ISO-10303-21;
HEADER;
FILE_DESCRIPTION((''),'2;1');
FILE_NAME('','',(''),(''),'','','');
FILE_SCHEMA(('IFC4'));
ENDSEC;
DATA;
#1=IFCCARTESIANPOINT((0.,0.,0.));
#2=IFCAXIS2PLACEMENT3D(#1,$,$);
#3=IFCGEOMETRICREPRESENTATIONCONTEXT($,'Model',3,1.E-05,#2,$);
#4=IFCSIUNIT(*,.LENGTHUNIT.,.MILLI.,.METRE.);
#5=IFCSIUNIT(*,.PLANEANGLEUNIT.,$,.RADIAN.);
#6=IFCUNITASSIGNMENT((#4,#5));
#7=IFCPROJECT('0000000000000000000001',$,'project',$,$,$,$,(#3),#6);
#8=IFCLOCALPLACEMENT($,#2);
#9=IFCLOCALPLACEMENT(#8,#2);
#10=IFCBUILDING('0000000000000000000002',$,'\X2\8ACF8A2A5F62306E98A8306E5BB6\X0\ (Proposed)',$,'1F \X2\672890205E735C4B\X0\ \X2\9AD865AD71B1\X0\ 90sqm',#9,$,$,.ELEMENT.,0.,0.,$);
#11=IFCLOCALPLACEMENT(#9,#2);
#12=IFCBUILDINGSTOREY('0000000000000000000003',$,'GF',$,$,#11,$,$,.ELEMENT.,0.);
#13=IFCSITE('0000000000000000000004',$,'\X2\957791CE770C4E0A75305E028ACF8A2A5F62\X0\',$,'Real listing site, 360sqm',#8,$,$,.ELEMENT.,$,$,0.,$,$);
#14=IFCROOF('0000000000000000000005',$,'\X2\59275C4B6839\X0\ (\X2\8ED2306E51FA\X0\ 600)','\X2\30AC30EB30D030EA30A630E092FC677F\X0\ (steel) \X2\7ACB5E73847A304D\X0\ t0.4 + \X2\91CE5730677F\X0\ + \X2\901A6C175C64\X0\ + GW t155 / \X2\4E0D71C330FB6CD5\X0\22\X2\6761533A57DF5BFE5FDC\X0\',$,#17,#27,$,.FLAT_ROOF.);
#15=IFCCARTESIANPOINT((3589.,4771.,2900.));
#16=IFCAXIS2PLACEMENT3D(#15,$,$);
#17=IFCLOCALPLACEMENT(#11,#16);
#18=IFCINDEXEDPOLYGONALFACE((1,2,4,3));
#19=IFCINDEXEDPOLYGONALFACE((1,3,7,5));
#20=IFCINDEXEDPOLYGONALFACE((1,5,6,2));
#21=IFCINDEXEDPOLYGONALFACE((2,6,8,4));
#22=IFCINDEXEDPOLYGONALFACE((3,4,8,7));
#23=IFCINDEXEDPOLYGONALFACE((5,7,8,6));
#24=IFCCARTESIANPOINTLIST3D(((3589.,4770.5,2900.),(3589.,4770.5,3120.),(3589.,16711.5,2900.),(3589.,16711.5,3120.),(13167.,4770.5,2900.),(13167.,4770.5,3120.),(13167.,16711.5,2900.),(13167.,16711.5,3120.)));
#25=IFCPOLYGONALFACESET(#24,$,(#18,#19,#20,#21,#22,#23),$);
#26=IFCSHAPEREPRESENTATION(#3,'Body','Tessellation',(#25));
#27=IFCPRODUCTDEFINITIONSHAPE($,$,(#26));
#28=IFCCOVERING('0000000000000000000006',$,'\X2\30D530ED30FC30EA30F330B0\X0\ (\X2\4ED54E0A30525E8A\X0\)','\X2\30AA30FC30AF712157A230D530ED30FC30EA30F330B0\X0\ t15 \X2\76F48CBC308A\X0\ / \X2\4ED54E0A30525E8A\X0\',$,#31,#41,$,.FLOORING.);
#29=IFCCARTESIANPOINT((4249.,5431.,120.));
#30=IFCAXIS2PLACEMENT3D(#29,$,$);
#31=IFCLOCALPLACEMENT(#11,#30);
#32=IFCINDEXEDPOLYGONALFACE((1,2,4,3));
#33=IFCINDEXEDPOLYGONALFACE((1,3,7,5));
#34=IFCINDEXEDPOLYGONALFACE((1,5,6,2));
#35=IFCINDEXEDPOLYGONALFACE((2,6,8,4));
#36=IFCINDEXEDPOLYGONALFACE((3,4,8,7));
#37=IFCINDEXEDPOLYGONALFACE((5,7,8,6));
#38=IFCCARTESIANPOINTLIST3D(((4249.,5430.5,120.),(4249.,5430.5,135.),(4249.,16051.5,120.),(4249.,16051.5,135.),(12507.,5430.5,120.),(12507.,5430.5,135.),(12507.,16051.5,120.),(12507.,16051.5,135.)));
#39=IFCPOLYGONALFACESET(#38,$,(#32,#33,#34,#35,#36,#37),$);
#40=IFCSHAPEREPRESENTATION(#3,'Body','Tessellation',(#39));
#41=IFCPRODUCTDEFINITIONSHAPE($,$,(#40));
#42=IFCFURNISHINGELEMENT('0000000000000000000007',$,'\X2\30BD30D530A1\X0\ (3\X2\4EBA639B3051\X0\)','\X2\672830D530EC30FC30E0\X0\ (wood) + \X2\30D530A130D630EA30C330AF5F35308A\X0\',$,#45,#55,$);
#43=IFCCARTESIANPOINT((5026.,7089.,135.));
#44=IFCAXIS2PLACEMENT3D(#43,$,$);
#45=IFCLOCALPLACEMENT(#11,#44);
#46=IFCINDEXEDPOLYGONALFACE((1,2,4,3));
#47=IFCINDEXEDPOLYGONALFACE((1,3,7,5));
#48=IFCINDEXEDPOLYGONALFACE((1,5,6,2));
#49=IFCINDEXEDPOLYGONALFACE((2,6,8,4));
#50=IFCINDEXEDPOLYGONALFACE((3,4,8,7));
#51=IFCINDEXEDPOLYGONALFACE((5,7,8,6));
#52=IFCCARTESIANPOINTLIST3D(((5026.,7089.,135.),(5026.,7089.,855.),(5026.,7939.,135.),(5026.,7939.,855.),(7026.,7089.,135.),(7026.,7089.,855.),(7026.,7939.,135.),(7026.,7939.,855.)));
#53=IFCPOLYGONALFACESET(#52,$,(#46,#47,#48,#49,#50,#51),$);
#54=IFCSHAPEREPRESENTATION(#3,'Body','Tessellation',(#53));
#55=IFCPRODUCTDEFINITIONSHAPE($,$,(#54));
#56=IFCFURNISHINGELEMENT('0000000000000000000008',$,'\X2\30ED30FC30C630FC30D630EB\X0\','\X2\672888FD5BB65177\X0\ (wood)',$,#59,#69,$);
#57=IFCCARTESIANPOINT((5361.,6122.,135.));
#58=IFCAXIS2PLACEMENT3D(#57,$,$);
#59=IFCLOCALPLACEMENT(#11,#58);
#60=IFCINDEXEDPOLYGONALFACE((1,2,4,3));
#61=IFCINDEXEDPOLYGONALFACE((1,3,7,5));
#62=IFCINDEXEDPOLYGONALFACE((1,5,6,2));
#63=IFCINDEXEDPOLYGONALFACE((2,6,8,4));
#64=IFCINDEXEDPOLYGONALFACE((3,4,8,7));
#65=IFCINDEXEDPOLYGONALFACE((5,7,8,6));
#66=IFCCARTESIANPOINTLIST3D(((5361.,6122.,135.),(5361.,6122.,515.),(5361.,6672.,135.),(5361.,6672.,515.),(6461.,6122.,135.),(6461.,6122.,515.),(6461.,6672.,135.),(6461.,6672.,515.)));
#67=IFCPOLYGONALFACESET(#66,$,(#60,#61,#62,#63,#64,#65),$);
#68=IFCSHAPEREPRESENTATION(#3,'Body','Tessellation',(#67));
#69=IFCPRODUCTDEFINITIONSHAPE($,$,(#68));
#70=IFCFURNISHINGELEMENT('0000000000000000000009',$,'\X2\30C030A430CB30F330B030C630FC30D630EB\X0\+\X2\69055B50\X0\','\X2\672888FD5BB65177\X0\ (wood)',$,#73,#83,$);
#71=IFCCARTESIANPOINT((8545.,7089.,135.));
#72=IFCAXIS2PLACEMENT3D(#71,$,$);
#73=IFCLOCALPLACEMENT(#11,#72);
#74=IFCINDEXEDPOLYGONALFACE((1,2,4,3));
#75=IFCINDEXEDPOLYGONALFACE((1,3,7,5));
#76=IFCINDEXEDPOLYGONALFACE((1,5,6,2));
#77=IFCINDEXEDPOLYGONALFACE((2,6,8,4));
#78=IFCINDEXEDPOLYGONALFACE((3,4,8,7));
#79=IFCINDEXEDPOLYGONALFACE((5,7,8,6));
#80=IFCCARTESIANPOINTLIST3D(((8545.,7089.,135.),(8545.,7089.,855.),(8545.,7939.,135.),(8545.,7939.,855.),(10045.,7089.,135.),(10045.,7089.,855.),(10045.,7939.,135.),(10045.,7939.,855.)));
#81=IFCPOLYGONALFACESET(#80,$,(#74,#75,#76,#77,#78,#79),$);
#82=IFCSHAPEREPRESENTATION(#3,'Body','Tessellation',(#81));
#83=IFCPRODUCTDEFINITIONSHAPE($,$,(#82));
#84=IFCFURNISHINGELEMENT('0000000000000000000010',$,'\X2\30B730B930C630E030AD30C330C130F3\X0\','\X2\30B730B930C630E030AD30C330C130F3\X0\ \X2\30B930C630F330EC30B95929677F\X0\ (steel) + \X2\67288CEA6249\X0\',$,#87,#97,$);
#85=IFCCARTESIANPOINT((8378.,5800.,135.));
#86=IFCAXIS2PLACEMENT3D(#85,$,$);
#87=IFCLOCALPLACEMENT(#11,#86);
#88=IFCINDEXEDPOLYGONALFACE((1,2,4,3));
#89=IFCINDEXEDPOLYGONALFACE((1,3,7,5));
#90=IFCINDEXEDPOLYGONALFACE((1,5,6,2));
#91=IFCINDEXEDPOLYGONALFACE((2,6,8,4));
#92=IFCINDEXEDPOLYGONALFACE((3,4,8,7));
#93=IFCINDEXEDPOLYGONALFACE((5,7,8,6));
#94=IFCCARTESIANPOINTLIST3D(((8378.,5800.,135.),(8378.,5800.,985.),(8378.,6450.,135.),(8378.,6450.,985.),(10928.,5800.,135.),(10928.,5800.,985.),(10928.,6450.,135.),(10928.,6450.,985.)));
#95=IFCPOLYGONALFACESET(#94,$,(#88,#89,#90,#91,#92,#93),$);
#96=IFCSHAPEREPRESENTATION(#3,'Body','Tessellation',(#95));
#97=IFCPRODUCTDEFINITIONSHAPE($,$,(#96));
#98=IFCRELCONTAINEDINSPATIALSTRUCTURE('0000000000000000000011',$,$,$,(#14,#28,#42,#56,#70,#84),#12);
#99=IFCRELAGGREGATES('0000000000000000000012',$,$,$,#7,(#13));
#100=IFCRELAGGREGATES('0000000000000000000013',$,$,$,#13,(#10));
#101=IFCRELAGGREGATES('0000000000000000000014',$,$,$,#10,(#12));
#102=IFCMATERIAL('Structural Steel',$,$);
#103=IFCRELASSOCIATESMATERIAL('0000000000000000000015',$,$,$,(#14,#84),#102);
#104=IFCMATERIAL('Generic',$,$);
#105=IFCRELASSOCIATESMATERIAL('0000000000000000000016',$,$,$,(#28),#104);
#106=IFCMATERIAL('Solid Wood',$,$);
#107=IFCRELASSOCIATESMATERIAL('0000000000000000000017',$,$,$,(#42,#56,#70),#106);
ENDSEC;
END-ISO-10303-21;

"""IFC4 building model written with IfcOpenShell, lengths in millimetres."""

from ifc_helpers import new_model, si_unit, frame, frame_2d, origin, place, context, project, spatial, rectangle, extrude, material, element, save


model = new_model("IFC4")

# Units and contexts
model_context = context("Model", 3, precision=1e-05, world=origin())
ifc_project = project(units=[si_unit("LENGTHUNIT", "METRE", prefix="MILLI"), si_unit("PLANEANGLEUNIT", "RADIAN")], contexts=[model_context])

# Site, building, storey
site_placement = place(None, origin())
site = spatial("IfcSite", under=ifc_project, at=site_placement, Name="長野県上田市諏訪形", ObjectType="Real listing site, 360sqm", CompositionType="ELEMENT", RefElevation=0.0)
building_placement = place(site_placement, origin())
building = spatial("IfcBuilding", under=site, at=building_placement, Name="諏訪形の風の家 (Proposed)", ObjectType="1F 木造平屋 高断熱 90sqm", CompositionType="ELEMENT", ElevationOfRefHeight=0.0, ElevationOfTerrain=0.0)
storey_placement = place(building_placement, origin())
storey = spatial("IfcBuildingStorey", under=building, at=storey_placement, Name="GF", CompositionType="ELEMENT", Elevation=0.0)

# Shared definitions
ifc_material_1 = material(Name="Solid Wood")

# Roof
ifc_material_2 = material(Name="Structural Steel")
roof_placement = place(storey_placement, frame((3589.0, 4771.0, 2900.0)))
element("IfcRoof", 1, at=roof_placement, inside=storey, material=ifc_material_2, Name="大屋根 (軒の出 600)", Description="ガルバリウム鋼板 (steel) 立平葺き t0.4 + 野地板 + 通気層 + GW t155 / 不燃・法22条区域対応", PredefinedType="FLAT_ROOF", context=model_context, shape_type="SweptSolid", body=[
    extrude(rectangle(XDim=9578.0, YDim=11941.0, at=frame_2d((4789.0, 5970.0))), frame((3589.0, 4771.0, 2900.0)), (0.0, 0.0, 1.0), 220.0),
])

# Covering
ifc_material_3 = material(Name="Generic")
covering_placement = place(storey_placement, frame((4249.0, 5431.0, 120.0)))
element("IfcCovering", 2, at=covering_placement, inside=storey, material=ifc_material_3, Name="フローリング (仕上げ床)", Description="オーク無垢フローリング t15 直貼り / 仕上げ床", PredefinedType="FLOORING", context=model_context, shape_type="SweptSolid", body=[
    extrude(rectangle(XDim=8258.0, YDim=10621.0, at=frame_2d((4129.0, 5310.0))), frame((4249.0, 5431.0, 120.0)), (0.0, 0.0, 1.0), 15.0),
])

# Furnishing elements
furnishing_1_placement = place(storey_placement, frame((5026.0, 7089.0, 135.0)))
element("IfcFurnishingElement", 3, at=furnishing_1_placement, inside=storey, material=ifc_material_1, Name="ソファ (3人掛け)", Description="木フレーム (wood) + ファブリック張り", context=model_context, shape_type="SweptSolid", body=[
    extrude(rectangle(XDim=2000.0, YDim=850.0, at=frame_2d((1000.0, 425.0))), frame((5026.0, 7089.0, 135.0)), (0.0, 0.0, 1.0), 720.0),
])
furnishing_2_placement = place(storey_placement, frame((5361.0, 6122.0, 135.0)))
element("IfcFurnishingElement", 4, at=furnishing_2_placement, inside=storey, material=ifc_material_1, Name="ローテーブル", Description="木製家具 (wood)", context=model_context, shape_type="SweptSolid", body=[
    extrude(rectangle(XDim=1100.0, YDim=550.0, at=frame_2d((550.0, 275.0))), frame((5361.0, 6122.0, 135.0)), (0.0, 0.0, 1.0), 380.0),
])
furnishing_3_placement = place(storey_placement, frame((8545.0, 7089.0, 135.0)))
element("IfcFurnishingElement", 5, at=furnishing_3_placement, inside=storey, material=ifc_material_1, Name="ダイニングテーブル+椅子", Description="木製家具 (wood)", context=model_context, shape_type="SweptSolid", body=[
    extrude(rectangle(XDim=1500.0, YDim=850.0, at=frame_2d((750.0, 425.0))), frame((8545.0, 7089.0, 135.0)), (0.0, 0.0, 1.0), 720.0),
])
furnishing_4_placement = place(storey_placement, frame((8378.0, 5800.0, 135.0)))
element("IfcFurnishingElement", 6, at=furnishing_4_placement, inside=storey, material=ifc_material_2, Name="システムキッチン", Description="システムキッチン ステンレス天板 (steel) + 木質扉", context=model_context, shape_type="SweptSolid", body=[
    extrude(rectangle(XDim=2550.0, YDim=650.0, at=frame_2d((1275.0, 325.0))), frame((8378.0, 5800.0, 135.0)), (0.0, 0.0, 1.0), 850.0),
])

save(model, "model.ifc")
